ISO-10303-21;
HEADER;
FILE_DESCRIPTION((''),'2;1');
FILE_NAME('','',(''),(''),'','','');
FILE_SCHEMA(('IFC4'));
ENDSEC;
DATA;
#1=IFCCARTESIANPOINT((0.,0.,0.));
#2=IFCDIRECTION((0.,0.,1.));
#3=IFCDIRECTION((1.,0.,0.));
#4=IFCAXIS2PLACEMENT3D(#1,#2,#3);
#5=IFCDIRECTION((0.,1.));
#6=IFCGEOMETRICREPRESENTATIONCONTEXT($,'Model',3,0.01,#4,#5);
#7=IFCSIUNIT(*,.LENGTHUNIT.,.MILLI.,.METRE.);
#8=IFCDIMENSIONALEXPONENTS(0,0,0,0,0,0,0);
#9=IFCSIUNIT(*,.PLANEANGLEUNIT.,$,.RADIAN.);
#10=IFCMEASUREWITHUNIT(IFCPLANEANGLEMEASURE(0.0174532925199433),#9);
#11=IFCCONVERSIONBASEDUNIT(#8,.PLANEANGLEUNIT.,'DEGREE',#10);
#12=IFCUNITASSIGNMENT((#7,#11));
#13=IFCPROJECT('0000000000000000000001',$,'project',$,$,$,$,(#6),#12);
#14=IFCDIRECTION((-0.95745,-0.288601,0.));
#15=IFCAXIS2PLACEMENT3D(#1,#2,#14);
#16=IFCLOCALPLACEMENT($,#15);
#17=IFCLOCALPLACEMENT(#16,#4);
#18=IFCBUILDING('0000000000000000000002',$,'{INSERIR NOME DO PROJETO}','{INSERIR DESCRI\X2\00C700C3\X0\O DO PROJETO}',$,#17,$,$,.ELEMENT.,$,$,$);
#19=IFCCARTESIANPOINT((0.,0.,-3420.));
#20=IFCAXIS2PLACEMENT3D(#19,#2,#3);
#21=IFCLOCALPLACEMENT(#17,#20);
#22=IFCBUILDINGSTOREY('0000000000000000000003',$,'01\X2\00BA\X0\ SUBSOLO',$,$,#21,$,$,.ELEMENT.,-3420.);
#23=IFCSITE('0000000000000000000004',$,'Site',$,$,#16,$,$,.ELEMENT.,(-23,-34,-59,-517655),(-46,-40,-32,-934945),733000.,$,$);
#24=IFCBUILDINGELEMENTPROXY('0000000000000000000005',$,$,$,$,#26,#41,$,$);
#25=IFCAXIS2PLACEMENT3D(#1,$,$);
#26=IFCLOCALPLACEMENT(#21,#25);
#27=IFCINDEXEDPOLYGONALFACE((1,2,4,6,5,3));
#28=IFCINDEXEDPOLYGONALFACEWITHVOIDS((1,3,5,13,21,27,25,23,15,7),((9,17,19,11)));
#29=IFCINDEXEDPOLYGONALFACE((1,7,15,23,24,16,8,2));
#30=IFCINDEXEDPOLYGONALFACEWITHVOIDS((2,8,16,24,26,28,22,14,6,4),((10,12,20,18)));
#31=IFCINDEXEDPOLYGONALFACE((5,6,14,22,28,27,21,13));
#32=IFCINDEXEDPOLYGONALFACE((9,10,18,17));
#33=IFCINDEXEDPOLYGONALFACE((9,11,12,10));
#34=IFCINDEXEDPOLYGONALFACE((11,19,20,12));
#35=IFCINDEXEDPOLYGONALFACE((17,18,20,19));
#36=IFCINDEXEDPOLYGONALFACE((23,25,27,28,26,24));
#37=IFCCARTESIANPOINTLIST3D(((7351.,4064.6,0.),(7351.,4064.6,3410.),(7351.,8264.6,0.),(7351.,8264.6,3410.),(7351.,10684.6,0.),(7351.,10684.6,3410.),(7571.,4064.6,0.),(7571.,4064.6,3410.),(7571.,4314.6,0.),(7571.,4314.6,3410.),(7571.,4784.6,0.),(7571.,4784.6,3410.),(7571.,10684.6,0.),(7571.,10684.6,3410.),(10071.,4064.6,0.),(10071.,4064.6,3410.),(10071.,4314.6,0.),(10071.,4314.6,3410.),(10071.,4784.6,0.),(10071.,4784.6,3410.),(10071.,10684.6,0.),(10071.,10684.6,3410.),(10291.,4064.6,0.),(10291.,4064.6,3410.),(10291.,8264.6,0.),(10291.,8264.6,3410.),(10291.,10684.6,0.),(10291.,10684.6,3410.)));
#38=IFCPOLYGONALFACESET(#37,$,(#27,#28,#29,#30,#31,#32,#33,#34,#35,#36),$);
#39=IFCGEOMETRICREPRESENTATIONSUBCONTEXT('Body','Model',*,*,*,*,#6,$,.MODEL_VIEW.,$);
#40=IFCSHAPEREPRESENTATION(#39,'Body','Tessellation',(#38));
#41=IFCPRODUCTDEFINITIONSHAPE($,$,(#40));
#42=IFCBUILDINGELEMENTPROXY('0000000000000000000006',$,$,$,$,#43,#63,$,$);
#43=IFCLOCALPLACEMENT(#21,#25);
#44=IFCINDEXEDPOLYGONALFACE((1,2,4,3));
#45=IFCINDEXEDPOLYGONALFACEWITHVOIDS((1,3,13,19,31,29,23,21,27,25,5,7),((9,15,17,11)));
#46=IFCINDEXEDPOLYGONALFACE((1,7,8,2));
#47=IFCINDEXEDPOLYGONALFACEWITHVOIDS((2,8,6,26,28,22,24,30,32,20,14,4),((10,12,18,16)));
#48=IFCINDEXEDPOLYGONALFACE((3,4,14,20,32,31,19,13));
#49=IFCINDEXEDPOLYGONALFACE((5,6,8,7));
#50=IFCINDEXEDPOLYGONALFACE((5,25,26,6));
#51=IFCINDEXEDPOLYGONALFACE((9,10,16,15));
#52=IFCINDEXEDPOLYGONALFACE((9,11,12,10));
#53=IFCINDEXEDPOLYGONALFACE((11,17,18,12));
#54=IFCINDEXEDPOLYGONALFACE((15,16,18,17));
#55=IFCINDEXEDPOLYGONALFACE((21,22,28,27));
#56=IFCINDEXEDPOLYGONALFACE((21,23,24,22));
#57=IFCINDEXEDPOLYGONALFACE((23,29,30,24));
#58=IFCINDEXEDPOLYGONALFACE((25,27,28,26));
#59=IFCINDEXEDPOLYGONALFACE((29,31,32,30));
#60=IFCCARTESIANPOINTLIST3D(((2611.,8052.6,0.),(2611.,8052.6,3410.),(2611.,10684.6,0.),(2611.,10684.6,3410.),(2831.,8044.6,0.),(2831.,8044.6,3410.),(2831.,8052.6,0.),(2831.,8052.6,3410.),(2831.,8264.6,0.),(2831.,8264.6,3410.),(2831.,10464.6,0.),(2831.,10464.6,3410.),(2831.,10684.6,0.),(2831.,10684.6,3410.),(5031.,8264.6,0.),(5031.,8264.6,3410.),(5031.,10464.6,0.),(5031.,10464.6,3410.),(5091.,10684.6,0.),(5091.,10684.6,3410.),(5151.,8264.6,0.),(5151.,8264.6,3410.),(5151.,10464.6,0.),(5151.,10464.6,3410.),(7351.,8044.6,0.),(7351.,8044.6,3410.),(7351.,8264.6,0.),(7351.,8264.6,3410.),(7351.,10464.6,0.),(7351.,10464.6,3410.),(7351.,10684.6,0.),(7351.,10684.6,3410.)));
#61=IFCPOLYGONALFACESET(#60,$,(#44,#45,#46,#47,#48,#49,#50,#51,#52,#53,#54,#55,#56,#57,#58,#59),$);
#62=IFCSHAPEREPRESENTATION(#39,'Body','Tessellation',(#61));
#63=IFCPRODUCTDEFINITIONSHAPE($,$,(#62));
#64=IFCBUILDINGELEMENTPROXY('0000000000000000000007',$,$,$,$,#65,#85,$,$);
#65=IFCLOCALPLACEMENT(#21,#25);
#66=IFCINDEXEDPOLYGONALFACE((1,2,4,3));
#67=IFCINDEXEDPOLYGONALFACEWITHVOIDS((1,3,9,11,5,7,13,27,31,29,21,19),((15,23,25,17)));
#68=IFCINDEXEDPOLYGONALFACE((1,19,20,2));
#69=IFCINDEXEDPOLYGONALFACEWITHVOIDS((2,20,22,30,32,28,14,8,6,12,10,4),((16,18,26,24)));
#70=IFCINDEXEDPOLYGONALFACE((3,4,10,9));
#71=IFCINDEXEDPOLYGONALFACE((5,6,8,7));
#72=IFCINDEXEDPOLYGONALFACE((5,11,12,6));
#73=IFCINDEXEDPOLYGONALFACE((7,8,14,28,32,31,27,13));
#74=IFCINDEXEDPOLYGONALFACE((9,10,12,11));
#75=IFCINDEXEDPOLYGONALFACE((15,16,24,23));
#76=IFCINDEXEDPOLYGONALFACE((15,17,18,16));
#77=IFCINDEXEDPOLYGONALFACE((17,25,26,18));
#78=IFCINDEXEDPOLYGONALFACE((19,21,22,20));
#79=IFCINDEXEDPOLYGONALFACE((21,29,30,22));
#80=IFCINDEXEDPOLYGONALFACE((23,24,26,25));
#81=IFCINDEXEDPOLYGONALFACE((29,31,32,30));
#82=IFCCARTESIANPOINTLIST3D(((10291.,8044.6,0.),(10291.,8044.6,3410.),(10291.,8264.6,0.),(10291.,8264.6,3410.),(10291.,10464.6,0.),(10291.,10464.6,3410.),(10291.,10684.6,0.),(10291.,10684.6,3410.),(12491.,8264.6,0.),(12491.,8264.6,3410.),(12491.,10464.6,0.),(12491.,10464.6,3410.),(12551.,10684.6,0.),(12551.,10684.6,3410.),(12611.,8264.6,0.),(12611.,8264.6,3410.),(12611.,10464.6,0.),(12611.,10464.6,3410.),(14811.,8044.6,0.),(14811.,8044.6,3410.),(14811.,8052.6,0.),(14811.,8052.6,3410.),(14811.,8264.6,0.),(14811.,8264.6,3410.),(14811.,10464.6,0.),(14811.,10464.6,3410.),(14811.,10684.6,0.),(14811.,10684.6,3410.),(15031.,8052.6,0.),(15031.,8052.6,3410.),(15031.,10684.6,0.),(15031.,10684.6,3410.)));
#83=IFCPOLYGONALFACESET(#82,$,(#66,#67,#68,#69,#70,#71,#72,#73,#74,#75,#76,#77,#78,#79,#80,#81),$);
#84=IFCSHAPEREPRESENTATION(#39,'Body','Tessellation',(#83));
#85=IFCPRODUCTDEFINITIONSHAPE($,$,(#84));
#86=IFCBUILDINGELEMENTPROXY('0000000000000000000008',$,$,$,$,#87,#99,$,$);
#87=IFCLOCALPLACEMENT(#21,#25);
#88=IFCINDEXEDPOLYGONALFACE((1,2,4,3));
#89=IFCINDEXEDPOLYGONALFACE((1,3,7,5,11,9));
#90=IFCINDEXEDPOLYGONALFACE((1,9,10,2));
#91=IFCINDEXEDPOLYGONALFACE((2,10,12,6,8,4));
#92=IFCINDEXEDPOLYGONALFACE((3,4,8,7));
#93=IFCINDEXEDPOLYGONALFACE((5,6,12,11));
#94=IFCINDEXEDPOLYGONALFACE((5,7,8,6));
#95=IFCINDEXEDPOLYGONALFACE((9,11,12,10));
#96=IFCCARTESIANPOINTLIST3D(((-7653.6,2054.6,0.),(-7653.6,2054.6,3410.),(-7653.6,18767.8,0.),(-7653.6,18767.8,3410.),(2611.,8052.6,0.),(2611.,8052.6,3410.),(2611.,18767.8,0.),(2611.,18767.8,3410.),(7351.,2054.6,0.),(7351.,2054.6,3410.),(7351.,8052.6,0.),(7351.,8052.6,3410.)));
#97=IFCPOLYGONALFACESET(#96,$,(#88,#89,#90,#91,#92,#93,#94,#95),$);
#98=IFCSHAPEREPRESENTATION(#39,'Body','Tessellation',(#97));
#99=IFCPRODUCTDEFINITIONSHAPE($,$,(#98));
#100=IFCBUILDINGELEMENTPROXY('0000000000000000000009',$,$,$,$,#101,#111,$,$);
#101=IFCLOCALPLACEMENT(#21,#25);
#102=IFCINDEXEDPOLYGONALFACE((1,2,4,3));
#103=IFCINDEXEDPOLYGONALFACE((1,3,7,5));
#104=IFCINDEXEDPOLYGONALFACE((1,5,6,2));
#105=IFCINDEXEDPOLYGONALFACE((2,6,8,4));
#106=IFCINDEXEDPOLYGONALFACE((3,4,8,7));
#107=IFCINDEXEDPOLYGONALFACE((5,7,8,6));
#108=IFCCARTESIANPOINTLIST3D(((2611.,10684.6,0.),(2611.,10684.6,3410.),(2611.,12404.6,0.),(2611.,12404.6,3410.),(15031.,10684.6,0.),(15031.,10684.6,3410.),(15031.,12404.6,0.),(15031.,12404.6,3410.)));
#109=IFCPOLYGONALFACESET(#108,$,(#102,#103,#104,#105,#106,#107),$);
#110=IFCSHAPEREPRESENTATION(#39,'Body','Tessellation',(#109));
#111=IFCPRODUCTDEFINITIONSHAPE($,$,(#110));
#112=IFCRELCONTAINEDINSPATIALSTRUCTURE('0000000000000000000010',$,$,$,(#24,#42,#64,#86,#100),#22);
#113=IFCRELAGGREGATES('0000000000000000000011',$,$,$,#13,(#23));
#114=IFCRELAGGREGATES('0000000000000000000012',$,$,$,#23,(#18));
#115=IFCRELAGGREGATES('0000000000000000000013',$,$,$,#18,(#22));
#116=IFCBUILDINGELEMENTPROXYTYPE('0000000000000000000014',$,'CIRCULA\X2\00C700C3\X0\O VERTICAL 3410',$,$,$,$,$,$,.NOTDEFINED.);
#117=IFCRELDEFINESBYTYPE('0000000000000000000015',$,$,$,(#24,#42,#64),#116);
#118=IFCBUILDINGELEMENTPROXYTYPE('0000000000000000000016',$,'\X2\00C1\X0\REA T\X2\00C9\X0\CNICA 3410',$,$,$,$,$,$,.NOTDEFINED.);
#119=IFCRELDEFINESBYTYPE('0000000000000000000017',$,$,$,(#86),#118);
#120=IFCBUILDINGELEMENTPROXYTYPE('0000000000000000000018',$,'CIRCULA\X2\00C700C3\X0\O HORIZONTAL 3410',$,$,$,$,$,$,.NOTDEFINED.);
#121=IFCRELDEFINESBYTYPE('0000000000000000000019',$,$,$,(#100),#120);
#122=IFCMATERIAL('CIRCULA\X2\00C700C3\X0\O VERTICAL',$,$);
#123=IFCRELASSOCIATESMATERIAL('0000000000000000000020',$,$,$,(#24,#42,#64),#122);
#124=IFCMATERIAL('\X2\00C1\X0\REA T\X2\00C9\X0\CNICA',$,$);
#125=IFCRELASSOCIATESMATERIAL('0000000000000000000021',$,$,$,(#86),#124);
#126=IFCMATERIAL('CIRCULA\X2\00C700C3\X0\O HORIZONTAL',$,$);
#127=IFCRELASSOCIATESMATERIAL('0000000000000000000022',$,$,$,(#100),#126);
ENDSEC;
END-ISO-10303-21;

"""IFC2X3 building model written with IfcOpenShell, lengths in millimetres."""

from ifc_helpers import new_model, entity, si_unit, converted_unit, direction, frame, origin_with_axes, place, context, subcontext, project, spatial, polyline, outline, extrude, material, type_object, element, save


model = new_model("IFC2X3")

# Units and contexts
model_context = context("Model", 3, precision=0.01, world=origin_with_axes(), true_north=direction((0.0, 1.0)))
body_context = subcontext(model_context, "Body", "Model", "MODEL_VIEW")
ifc_project = project(units=[si_unit("LENGTHUNIT", "METRE", prefix="MILLI"), converted_unit("PLANEANGLEUNIT", "DEGREE", entity("IfcPlaneAngleMeasure", 0.0174532925199433), si_unit("PLANEANGLEUNIT", "RADIAN"), dimensions=[0, 0, 0, 0, 0, 0, 0])], contexts=[model_context])

# Site, building, storey
site_placement = place(None, frame((0.0, 0.0, 0.0), z_axis=(0.0, 0.0, 1.0), x_axis=(-0.95745, -0.288601, 0.0)))
site = spatial("IfcSite", under=ifc_project, at=site_placement, Name="Site", CompositionType="ELEMENT", RefLatitude=(-23, -34, -59, -517655), RefLongitude=(-46, -40, -32, -934945), RefElevation=733000.0)
building_placement = place(site_placement, origin_with_axes())
building = spatial("IfcBuilding", under=site, at=building_placement, Name="{INSERIR NOME DO PROJETO}", Description="{INSERIR DESCRIÇÃO DO PROJETO}", CompositionType="ELEMENT")
storey_placement = place(building_placement, frame((0.0, 0.0, -3420.0), z_axis=(0.0, 0.0, 1.0), x_axis=(1.0, 0.0, 0.0)))
storey = spatial("IfcBuildingStorey", under=building, at=storey_placement, Name="01º SUBSOLO", CompositionType="ELEMENT", Elevation=-3420.0)

# Building element proxies
ifc_material_1 = material(Name="CIRCULAÇÃO VERTICAL")
building_element_proxy_type_1 = type_object("IfcBuildingElementProxyType", Name="CIRCULAÇÃO VERTICAL 3410", PredefinedType="NOTDEFINED")
proxy_1_placement = place(storey_placement, frame((7571.0, 10684.6, 0.0), z_axis=(0.0, 0.0, 1.0), x_axis=(1.0, 0.0, 0.0)))
element("IfcBuildingElementProxy", 1, at=proxy_1_placement, inside=storey, type_object=building_element_proxy_type_1, material=ifc_material_1, context=body_context, shape_type="SweptSolid", body=[
    extrude(outline(polyline([(0.0, 0.0), (-220.0, 0.0), (-220.0, -2420.0), (-220.0, -6620.0), (0.0, -6620.0), (2500.0, -6620.0), (2720.0, -6620.0), (2720.0, -2420.0), (2720.0, 0.0), (2500.0, 0.0), (0.0, 0.0)]), holes=[polyline([(2500.0, -6370.0), (0.0, -6370.0), (0.0, -5900.0), (2500.0, -5900.0), (2500.0, -6370.0)])]), origin_with_axes(), (0.0, 0.0, 1.0), 3410.0),
])
proxy_2_placement = place(storey_placement, frame((7351.0, 10464.6, 0.0), z_axis=(0.0, 0.0, 1.0), x_axis=(1.0, 0.0, 0.0)))
element("IfcBuildingElementProxy", 2, at=proxy_2_placement, inside=storey, type_object=building_element_proxy_type_1, material=ifc_material_1, context=body_context, shape_type="SweptSolid", body=[
    extrude(outline(polyline([(0.0, 0.0), (0.0, 220.0), (-2260.0, 220.0), (-4520.0, 220.0), (-4740.0, 220.0), (-4740.0, -2412.1), (-4520.0, -2412.1), (-4520.0, -2420.0), (0.0, -2420.0), (0.0, -2200.0), (-2200.0, -2200.0), (-2200.0, 0.0), (0.0, 0.0)]), holes=[polyline([(-2320.0, 0.0), (-2320.0, -2200.0), (-4520.0, -2200.0), (-4520.0, 0.0), (-2320.0, 0.0)])]), origin_with_axes(), (0.0, 0.0, 1.0), 3410.0),
])
proxy_3_placement = place(storey_placement, frame((10291.0, 10464.6, 0.0), z_axis=(0.0, 0.0, 1.0), x_axis=(1.0, 0.0, 0.0)))
element("IfcBuildingElementProxy", 3, at=proxy_3_placement, inside=storey, type_object=building_element_proxy_type_1, material=ifc_material_1, context=body_context, shape_type="SweptSolid", body=[
    extrude(outline(polyline([(0.0, 0.0), (2200.0, 0.0), (2200.0, -2200.0), (0.0, -2200.0), (0.0, -2420.0), (4520.0, -2420.0), (4520.0, -2412.1), (4740.0, -2412.1), (4740.0, 220.0), (4520.0, 220.0), (2260.0, 220.0), (0.0, 220.0), (0.0, 0.0)]), holes=[polyline([(2320.0, 0.0), (4520.0, 0.0), (4520.0, -2200.0), (2320.0, -2200.0), (2320.0, 0.0)])]), origin_with_axes(), (0.0, 0.0, 1.0), 3410.0),
])
ifc_material_2 = material(Name="ÁREA TÉCNICA")
building_element_proxy_type_2 = type_object("IfcBuildingElementProxyType", Name="ÁREA TÉCNICA 3410", PredefinedType="NOTDEFINED")
proxy_4_placement = place(storey_placement, frame((-7653.6, 18767.8, 0.0), z_axis=(0.0, 0.0, 1.0), x_axis=(1.0, 0.0, 0.0)))
element("IfcBuildingElementProxy", 4, at=proxy_4_placement, inside=storey, type_object=building_element_proxy_type_2, material=ifc_material_2, context=body_context, shape_type="SweptSolid", body=[
    extrude(outline(polyline([(0.0, 0.0), (0.0, -16713.2), (15004.6, -16713.2), (15004.6, -10715.2), (10264.6, -10715.2), (10264.6, 0.0), (0.0, 0.0)])), origin_with_axes(), (0.0, 0.0, 1.0), 3410.0),
])
ifc_material_3 = material(Name="CIRCULAÇÃO HORIZONTAL")
building_element_proxy_type_3 = type_object("IfcBuildingElementProxyType", Name="CIRCULAÇÃO HORIZONTAL 3410", PredefinedType="NOTDEFINED")
proxy_5_placement = place(storey_placement, frame((2611.0, 10684.6, 0.0), z_axis=(0.0, 0.0, 1.0), x_axis=(1.0, 0.0, 0.0)))
element("IfcBuildingElementProxy", 5, at=proxy_5_placement, inside=storey, type_object=building_element_proxy_type_3, material=ifc_material_3, context=body_context, shape_type="SweptSolid", body=[
    extrude(outline(polyline([(0.0, 0.0), (12420.0, 0.0), (12420.0, 1720.0), (0.0, 1720.0), (0.0, 0.0)])), origin_with_axes(), (0.0, 0.0, 1.0), 3410.0),
])

save(model, "model.ifc")
